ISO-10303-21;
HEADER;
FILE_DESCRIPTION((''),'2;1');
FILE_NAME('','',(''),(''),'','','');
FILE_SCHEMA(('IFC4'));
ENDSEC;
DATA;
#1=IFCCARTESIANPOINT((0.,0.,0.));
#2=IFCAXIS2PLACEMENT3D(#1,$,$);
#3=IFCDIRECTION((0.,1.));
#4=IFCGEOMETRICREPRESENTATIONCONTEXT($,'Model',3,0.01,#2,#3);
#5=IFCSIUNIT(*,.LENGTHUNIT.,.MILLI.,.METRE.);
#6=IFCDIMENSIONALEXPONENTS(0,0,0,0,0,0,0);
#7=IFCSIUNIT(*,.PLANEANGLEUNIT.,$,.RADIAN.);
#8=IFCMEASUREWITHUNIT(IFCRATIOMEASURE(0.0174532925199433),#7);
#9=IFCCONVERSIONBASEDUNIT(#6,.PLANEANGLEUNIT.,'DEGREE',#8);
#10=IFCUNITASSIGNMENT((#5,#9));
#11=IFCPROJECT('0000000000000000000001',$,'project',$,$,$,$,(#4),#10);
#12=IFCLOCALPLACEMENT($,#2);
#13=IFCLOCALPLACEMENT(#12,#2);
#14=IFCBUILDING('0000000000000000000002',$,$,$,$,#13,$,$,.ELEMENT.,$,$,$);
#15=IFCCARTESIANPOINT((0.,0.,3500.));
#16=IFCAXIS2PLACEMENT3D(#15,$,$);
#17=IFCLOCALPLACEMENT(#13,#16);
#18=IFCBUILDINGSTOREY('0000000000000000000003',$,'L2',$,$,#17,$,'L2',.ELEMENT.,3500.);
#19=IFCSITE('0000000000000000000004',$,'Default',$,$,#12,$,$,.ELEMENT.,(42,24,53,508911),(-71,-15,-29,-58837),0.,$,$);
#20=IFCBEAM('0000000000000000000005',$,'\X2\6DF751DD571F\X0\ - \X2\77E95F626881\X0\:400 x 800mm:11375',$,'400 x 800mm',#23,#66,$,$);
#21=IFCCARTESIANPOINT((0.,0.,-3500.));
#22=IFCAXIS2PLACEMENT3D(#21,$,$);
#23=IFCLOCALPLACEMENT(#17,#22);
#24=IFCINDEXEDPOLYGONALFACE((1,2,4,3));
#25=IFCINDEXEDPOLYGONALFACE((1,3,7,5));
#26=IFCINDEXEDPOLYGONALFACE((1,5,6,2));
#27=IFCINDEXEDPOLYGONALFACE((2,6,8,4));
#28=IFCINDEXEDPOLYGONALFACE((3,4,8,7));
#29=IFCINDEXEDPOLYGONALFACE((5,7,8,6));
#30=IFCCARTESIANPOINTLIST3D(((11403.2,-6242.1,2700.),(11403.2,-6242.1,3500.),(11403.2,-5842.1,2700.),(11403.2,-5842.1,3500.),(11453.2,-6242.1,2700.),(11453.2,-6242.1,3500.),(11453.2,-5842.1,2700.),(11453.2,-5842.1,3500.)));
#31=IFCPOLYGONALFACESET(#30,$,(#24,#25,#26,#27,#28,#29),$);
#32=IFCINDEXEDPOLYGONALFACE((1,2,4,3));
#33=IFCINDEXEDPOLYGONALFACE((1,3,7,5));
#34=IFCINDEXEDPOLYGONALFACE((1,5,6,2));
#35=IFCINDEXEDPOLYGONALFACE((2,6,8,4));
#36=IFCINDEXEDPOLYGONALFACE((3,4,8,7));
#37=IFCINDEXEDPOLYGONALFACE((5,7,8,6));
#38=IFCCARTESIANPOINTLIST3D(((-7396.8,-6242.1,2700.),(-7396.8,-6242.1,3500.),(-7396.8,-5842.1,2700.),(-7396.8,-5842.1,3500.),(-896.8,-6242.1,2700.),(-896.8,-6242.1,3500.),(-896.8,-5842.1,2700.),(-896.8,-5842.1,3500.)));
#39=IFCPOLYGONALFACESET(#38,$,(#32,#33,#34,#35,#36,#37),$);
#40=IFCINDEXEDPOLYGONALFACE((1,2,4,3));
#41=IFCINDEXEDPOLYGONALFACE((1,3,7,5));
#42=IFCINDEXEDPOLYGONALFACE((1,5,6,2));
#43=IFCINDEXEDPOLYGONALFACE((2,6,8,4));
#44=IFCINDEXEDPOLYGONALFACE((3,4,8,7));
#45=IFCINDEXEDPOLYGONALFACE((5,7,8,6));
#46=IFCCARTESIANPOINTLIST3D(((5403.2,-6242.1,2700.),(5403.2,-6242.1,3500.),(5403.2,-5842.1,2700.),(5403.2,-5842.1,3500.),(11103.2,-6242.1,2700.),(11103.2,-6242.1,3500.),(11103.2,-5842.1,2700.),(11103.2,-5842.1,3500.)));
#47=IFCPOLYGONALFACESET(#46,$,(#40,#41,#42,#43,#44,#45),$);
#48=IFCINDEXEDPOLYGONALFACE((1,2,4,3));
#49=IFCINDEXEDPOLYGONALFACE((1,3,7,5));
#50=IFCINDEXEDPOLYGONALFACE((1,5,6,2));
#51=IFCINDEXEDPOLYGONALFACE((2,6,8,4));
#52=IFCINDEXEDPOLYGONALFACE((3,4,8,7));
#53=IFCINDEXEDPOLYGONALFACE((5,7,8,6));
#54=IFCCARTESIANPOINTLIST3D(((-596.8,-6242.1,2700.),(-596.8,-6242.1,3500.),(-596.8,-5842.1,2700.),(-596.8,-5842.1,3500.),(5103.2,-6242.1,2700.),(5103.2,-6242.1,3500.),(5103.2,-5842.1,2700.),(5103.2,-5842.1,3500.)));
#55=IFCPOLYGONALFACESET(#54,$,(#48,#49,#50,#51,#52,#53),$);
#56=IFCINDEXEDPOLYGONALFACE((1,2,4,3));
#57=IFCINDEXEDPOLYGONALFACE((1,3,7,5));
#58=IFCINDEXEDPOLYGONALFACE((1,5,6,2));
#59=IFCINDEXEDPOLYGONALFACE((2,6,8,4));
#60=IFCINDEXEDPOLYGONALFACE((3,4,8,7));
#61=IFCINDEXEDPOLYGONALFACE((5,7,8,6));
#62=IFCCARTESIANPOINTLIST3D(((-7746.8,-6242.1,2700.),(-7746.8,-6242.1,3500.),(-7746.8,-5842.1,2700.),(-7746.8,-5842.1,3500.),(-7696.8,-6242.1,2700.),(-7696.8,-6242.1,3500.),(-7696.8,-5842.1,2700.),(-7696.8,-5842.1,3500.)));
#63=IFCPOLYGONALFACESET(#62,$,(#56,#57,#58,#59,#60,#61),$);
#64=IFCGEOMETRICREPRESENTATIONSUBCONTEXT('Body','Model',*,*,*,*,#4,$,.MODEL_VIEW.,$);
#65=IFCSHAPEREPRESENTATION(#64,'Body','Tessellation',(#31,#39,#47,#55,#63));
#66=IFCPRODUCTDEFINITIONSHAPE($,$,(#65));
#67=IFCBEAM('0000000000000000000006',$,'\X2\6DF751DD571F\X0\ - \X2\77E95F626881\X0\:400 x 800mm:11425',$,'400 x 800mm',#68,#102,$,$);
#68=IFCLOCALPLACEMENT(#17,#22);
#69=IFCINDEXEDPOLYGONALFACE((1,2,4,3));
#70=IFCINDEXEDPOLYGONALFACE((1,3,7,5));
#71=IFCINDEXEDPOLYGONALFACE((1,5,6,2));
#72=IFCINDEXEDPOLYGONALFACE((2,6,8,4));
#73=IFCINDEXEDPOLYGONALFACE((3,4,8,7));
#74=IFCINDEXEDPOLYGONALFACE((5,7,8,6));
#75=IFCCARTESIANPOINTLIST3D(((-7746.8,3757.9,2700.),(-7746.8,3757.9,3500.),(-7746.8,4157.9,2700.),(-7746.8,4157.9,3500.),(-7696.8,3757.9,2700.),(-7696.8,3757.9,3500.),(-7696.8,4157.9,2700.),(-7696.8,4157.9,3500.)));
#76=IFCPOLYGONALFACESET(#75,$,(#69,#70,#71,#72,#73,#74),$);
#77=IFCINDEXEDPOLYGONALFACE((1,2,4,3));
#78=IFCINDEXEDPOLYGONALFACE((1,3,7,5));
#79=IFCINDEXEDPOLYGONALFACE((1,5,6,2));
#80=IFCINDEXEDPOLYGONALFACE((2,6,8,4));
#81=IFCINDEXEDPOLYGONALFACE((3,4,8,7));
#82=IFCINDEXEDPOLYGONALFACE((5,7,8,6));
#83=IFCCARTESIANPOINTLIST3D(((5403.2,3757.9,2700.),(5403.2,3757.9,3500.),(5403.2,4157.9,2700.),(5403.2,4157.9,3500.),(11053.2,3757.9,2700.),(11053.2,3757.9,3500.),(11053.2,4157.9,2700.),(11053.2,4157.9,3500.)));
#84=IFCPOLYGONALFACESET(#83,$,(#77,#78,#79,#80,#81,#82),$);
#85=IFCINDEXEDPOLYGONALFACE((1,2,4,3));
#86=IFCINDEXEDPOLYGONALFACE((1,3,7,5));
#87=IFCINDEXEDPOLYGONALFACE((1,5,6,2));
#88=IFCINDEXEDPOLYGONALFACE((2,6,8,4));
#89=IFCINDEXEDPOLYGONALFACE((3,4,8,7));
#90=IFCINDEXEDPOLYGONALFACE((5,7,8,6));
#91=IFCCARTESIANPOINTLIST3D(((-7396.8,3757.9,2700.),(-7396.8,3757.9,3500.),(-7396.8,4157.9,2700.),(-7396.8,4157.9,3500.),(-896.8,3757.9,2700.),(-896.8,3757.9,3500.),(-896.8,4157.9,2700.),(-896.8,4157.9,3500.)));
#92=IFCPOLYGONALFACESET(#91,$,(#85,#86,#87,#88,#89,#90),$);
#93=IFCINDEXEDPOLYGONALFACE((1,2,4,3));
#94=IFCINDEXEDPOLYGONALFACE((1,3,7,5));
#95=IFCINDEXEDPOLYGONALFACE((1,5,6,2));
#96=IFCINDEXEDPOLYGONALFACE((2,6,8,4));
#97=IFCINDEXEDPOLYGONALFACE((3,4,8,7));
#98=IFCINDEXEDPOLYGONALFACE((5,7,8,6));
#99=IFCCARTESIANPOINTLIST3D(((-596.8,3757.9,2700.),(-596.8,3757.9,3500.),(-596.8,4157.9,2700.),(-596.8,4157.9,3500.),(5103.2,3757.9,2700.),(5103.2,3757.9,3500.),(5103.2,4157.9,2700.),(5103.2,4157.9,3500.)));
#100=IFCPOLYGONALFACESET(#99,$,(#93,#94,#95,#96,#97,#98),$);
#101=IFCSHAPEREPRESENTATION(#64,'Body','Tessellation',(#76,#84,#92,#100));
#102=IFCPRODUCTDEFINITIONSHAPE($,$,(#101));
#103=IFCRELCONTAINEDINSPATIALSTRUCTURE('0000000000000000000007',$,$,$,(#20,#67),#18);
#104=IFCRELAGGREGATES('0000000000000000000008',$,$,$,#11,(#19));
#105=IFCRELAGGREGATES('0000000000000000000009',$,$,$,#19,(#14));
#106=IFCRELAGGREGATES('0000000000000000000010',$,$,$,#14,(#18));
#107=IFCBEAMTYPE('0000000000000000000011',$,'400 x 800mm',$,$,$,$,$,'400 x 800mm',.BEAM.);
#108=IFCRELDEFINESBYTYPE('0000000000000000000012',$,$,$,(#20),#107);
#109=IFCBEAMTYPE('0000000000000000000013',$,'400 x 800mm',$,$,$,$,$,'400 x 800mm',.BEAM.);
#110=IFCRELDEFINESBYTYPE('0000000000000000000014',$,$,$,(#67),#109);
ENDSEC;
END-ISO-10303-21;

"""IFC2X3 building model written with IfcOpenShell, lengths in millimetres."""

from ifc_helpers import new_model, entity, si_unit, converted_unit, direction, frame, frame_2d, origin, origin_2d_with_axis, place, context, subcontext, project, spatial, rectangle, extrude, source, transform, mapped, type_object, type_shapes, element, save


model = new_model("IFC2X3")

# Units and contexts
model_context = context("Model", 3, precision=0.01, world=origin(), true_north=direction((0.0, 1.0)))
body_context = subcontext(model_context, "Body", "Model", "MODEL_VIEW")
ifc_project = project(units=[si_unit("LENGTHUNIT", "METRE", prefix="MILLI"), converted_unit("PLANEANGLEUNIT", "DEGREE", entity("IfcRatioMeasure", 0.0174532925199433), si_unit("PLANEANGLEUNIT", "RADIAN"), dimensions=[0, 0, 0, 0, 0, 0, 0])], contexts=[model_context])

# Site, building, storey
site_placement = place(None, origin())
site = spatial("IfcSite", under=ifc_project, at=site_placement, Name="Default", CompositionType="ELEMENT", RefLatitude=(42, 24, 53, 508911), RefLongitude=(-71, -15, -29, -58837), RefElevation=0.0)
building_placement = place(site_placement, origin())
building = spatial("IfcBuilding", under=site, at=building_placement, CompositionType="ELEMENT")
storey_placement = place(building_placement, frame((0.0, 0.0, 3500.0)))
storey = spatial("IfcBuildingStorey", under=building, at=storey_placement, Name="L2", LongName="L2", CompositionType="ELEMENT", Elevation=3500.0)

# Beams
beam_type_1 = type_object("IfcBeamType", Name="400 x 800mm", ElementType="400 x 800mm", PredefinedType="BEAM")
shared_shape_1 = source(origin(), body_context, "Body", "SweptSolid", [
    extrude(rectangle(XDim=50.0, YDim=400.0, at=frame_2d((0.0, 0.0), x_axis=(1.0, 0.0))), frame((11428.2, -6042.1, 2700.0), z_axis=(0.0, 0.0, 1.0), x_axis=(-1.0, 0.0, 0.0)), (0.0, 0.0, 1.0), 800.0),
    extrude(rectangle(XDim=6500.0, YDim=400.0, at=frame_2d((640.0, -40.0), x_axis=(1.0, 0.0))), frame((-4786.8, -6002.1, 2700.0)), (0.0, 0.0, 1.0), 800.0),
    extrude(rectangle(XDim=5700.0, YDim=400.0, at=frame_2d((560.0, 40.0), x_axis=(1.0, 0.0))), frame((8813.2, -6002.1, 2700.0), z_axis=(0.0, 0.0, 1.0), x_axis=(-1.0, 0.0, 0.0)), (0.0, 0.0, 1.0), 800.0),
    extrude(rectangle(XDim=5700.0, YDim=400.0, at=origin_2d_with_axis()), frame((2253.2, -6042.1, 2700.0), z_axis=(0.0, 0.0, 1.0), x_axis=(-1.0, 0.0, 0.0)), (0.0, 0.0, 1.0), 800.0),
    extrude(rectangle(XDim=50.0, YDim=400.0, at=frame_2d((0.0, 0.0), x_axis=(1.0, 0.0))), frame((-7721.8, -6042.1, 2700.0)), (0.0, 0.0, 1.0), 800.0),
])
type_shapes(beam_type_1, [shared_shape_1])
beam_1_placement = place(storey_placement, frame((0.0, 0.0, -3500.0)))
element("IfcBeam", 1, at=beam_1_placement, inside=storey, type_object=beam_type_1, Name="混凝土 - 矩形梁:400 x 800mm:11375", ObjectType="400 x 800mm", context=body_context, shape_type="MappedRepresentation", body=[
    mapped(shared_shape_1, transform((0.0, 0.0, 0.0), scale=1.0)),
])
beam_type_2 = type_object("IfcBeamType", Name="400 x 800mm", ElementType="400 x 800mm", PredefinedType="BEAM")
shared_shape_2 = source(origin(), body_context, "Body", "SweptSolid", [
    extrude(rectangle(XDim=50.0, YDim=400.0, at=frame_2d((0.0, 0.0), x_axis=(1.0, 0.0))), frame((-7721.8, 3957.9, 2700.0)), (0.0, 0.0, 1.0), 800.0),
    extrude(rectangle(XDim=5650.0, YDim=400.0, at=origin_2d_with_axis()), frame((8228.2, 3957.9, 2700.0), z_axis=(0.0, 0.0, 1.0), x_axis=(-1.0, 0.0, 0.0)), (0.0, 0.0, 1.0), 800.0),
    extrude(rectangle(XDim=6500.0, YDim=400.0, at=frame_2d((640.0, 40.0), x_axis=(1.0, 0.0))), frame((-4786.8, 3917.9, 2700.0)), (0.0, 0.0, 1.0), 800.0),
    extrude(rectangle(XDim=5700.0, YDim=400.0, at=origin_2d_with_axis()), frame((2253.2, 3957.9, 2700.0)), (0.0, 0.0, 1.0), 800.0),
])
type_shapes(beam_type_2, [shared_shape_2])
beam_2_placement = place(storey_placement, frame((0.0, 0.0, -3500.0)))
element("IfcBeam", 2, at=beam_2_placement, inside=storey, type_object=beam_type_2, Name="混凝土 - 矩形梁:400 x 800mm:11425", ObjectType="400 x 800mm", context=body_context, shape_type="MappedRepresentation", body=[
    mapped(shared_shape_2, transform((0.0, 0.0, 0.0), scale=1.0)),
])

save(model, "model.ifc")
